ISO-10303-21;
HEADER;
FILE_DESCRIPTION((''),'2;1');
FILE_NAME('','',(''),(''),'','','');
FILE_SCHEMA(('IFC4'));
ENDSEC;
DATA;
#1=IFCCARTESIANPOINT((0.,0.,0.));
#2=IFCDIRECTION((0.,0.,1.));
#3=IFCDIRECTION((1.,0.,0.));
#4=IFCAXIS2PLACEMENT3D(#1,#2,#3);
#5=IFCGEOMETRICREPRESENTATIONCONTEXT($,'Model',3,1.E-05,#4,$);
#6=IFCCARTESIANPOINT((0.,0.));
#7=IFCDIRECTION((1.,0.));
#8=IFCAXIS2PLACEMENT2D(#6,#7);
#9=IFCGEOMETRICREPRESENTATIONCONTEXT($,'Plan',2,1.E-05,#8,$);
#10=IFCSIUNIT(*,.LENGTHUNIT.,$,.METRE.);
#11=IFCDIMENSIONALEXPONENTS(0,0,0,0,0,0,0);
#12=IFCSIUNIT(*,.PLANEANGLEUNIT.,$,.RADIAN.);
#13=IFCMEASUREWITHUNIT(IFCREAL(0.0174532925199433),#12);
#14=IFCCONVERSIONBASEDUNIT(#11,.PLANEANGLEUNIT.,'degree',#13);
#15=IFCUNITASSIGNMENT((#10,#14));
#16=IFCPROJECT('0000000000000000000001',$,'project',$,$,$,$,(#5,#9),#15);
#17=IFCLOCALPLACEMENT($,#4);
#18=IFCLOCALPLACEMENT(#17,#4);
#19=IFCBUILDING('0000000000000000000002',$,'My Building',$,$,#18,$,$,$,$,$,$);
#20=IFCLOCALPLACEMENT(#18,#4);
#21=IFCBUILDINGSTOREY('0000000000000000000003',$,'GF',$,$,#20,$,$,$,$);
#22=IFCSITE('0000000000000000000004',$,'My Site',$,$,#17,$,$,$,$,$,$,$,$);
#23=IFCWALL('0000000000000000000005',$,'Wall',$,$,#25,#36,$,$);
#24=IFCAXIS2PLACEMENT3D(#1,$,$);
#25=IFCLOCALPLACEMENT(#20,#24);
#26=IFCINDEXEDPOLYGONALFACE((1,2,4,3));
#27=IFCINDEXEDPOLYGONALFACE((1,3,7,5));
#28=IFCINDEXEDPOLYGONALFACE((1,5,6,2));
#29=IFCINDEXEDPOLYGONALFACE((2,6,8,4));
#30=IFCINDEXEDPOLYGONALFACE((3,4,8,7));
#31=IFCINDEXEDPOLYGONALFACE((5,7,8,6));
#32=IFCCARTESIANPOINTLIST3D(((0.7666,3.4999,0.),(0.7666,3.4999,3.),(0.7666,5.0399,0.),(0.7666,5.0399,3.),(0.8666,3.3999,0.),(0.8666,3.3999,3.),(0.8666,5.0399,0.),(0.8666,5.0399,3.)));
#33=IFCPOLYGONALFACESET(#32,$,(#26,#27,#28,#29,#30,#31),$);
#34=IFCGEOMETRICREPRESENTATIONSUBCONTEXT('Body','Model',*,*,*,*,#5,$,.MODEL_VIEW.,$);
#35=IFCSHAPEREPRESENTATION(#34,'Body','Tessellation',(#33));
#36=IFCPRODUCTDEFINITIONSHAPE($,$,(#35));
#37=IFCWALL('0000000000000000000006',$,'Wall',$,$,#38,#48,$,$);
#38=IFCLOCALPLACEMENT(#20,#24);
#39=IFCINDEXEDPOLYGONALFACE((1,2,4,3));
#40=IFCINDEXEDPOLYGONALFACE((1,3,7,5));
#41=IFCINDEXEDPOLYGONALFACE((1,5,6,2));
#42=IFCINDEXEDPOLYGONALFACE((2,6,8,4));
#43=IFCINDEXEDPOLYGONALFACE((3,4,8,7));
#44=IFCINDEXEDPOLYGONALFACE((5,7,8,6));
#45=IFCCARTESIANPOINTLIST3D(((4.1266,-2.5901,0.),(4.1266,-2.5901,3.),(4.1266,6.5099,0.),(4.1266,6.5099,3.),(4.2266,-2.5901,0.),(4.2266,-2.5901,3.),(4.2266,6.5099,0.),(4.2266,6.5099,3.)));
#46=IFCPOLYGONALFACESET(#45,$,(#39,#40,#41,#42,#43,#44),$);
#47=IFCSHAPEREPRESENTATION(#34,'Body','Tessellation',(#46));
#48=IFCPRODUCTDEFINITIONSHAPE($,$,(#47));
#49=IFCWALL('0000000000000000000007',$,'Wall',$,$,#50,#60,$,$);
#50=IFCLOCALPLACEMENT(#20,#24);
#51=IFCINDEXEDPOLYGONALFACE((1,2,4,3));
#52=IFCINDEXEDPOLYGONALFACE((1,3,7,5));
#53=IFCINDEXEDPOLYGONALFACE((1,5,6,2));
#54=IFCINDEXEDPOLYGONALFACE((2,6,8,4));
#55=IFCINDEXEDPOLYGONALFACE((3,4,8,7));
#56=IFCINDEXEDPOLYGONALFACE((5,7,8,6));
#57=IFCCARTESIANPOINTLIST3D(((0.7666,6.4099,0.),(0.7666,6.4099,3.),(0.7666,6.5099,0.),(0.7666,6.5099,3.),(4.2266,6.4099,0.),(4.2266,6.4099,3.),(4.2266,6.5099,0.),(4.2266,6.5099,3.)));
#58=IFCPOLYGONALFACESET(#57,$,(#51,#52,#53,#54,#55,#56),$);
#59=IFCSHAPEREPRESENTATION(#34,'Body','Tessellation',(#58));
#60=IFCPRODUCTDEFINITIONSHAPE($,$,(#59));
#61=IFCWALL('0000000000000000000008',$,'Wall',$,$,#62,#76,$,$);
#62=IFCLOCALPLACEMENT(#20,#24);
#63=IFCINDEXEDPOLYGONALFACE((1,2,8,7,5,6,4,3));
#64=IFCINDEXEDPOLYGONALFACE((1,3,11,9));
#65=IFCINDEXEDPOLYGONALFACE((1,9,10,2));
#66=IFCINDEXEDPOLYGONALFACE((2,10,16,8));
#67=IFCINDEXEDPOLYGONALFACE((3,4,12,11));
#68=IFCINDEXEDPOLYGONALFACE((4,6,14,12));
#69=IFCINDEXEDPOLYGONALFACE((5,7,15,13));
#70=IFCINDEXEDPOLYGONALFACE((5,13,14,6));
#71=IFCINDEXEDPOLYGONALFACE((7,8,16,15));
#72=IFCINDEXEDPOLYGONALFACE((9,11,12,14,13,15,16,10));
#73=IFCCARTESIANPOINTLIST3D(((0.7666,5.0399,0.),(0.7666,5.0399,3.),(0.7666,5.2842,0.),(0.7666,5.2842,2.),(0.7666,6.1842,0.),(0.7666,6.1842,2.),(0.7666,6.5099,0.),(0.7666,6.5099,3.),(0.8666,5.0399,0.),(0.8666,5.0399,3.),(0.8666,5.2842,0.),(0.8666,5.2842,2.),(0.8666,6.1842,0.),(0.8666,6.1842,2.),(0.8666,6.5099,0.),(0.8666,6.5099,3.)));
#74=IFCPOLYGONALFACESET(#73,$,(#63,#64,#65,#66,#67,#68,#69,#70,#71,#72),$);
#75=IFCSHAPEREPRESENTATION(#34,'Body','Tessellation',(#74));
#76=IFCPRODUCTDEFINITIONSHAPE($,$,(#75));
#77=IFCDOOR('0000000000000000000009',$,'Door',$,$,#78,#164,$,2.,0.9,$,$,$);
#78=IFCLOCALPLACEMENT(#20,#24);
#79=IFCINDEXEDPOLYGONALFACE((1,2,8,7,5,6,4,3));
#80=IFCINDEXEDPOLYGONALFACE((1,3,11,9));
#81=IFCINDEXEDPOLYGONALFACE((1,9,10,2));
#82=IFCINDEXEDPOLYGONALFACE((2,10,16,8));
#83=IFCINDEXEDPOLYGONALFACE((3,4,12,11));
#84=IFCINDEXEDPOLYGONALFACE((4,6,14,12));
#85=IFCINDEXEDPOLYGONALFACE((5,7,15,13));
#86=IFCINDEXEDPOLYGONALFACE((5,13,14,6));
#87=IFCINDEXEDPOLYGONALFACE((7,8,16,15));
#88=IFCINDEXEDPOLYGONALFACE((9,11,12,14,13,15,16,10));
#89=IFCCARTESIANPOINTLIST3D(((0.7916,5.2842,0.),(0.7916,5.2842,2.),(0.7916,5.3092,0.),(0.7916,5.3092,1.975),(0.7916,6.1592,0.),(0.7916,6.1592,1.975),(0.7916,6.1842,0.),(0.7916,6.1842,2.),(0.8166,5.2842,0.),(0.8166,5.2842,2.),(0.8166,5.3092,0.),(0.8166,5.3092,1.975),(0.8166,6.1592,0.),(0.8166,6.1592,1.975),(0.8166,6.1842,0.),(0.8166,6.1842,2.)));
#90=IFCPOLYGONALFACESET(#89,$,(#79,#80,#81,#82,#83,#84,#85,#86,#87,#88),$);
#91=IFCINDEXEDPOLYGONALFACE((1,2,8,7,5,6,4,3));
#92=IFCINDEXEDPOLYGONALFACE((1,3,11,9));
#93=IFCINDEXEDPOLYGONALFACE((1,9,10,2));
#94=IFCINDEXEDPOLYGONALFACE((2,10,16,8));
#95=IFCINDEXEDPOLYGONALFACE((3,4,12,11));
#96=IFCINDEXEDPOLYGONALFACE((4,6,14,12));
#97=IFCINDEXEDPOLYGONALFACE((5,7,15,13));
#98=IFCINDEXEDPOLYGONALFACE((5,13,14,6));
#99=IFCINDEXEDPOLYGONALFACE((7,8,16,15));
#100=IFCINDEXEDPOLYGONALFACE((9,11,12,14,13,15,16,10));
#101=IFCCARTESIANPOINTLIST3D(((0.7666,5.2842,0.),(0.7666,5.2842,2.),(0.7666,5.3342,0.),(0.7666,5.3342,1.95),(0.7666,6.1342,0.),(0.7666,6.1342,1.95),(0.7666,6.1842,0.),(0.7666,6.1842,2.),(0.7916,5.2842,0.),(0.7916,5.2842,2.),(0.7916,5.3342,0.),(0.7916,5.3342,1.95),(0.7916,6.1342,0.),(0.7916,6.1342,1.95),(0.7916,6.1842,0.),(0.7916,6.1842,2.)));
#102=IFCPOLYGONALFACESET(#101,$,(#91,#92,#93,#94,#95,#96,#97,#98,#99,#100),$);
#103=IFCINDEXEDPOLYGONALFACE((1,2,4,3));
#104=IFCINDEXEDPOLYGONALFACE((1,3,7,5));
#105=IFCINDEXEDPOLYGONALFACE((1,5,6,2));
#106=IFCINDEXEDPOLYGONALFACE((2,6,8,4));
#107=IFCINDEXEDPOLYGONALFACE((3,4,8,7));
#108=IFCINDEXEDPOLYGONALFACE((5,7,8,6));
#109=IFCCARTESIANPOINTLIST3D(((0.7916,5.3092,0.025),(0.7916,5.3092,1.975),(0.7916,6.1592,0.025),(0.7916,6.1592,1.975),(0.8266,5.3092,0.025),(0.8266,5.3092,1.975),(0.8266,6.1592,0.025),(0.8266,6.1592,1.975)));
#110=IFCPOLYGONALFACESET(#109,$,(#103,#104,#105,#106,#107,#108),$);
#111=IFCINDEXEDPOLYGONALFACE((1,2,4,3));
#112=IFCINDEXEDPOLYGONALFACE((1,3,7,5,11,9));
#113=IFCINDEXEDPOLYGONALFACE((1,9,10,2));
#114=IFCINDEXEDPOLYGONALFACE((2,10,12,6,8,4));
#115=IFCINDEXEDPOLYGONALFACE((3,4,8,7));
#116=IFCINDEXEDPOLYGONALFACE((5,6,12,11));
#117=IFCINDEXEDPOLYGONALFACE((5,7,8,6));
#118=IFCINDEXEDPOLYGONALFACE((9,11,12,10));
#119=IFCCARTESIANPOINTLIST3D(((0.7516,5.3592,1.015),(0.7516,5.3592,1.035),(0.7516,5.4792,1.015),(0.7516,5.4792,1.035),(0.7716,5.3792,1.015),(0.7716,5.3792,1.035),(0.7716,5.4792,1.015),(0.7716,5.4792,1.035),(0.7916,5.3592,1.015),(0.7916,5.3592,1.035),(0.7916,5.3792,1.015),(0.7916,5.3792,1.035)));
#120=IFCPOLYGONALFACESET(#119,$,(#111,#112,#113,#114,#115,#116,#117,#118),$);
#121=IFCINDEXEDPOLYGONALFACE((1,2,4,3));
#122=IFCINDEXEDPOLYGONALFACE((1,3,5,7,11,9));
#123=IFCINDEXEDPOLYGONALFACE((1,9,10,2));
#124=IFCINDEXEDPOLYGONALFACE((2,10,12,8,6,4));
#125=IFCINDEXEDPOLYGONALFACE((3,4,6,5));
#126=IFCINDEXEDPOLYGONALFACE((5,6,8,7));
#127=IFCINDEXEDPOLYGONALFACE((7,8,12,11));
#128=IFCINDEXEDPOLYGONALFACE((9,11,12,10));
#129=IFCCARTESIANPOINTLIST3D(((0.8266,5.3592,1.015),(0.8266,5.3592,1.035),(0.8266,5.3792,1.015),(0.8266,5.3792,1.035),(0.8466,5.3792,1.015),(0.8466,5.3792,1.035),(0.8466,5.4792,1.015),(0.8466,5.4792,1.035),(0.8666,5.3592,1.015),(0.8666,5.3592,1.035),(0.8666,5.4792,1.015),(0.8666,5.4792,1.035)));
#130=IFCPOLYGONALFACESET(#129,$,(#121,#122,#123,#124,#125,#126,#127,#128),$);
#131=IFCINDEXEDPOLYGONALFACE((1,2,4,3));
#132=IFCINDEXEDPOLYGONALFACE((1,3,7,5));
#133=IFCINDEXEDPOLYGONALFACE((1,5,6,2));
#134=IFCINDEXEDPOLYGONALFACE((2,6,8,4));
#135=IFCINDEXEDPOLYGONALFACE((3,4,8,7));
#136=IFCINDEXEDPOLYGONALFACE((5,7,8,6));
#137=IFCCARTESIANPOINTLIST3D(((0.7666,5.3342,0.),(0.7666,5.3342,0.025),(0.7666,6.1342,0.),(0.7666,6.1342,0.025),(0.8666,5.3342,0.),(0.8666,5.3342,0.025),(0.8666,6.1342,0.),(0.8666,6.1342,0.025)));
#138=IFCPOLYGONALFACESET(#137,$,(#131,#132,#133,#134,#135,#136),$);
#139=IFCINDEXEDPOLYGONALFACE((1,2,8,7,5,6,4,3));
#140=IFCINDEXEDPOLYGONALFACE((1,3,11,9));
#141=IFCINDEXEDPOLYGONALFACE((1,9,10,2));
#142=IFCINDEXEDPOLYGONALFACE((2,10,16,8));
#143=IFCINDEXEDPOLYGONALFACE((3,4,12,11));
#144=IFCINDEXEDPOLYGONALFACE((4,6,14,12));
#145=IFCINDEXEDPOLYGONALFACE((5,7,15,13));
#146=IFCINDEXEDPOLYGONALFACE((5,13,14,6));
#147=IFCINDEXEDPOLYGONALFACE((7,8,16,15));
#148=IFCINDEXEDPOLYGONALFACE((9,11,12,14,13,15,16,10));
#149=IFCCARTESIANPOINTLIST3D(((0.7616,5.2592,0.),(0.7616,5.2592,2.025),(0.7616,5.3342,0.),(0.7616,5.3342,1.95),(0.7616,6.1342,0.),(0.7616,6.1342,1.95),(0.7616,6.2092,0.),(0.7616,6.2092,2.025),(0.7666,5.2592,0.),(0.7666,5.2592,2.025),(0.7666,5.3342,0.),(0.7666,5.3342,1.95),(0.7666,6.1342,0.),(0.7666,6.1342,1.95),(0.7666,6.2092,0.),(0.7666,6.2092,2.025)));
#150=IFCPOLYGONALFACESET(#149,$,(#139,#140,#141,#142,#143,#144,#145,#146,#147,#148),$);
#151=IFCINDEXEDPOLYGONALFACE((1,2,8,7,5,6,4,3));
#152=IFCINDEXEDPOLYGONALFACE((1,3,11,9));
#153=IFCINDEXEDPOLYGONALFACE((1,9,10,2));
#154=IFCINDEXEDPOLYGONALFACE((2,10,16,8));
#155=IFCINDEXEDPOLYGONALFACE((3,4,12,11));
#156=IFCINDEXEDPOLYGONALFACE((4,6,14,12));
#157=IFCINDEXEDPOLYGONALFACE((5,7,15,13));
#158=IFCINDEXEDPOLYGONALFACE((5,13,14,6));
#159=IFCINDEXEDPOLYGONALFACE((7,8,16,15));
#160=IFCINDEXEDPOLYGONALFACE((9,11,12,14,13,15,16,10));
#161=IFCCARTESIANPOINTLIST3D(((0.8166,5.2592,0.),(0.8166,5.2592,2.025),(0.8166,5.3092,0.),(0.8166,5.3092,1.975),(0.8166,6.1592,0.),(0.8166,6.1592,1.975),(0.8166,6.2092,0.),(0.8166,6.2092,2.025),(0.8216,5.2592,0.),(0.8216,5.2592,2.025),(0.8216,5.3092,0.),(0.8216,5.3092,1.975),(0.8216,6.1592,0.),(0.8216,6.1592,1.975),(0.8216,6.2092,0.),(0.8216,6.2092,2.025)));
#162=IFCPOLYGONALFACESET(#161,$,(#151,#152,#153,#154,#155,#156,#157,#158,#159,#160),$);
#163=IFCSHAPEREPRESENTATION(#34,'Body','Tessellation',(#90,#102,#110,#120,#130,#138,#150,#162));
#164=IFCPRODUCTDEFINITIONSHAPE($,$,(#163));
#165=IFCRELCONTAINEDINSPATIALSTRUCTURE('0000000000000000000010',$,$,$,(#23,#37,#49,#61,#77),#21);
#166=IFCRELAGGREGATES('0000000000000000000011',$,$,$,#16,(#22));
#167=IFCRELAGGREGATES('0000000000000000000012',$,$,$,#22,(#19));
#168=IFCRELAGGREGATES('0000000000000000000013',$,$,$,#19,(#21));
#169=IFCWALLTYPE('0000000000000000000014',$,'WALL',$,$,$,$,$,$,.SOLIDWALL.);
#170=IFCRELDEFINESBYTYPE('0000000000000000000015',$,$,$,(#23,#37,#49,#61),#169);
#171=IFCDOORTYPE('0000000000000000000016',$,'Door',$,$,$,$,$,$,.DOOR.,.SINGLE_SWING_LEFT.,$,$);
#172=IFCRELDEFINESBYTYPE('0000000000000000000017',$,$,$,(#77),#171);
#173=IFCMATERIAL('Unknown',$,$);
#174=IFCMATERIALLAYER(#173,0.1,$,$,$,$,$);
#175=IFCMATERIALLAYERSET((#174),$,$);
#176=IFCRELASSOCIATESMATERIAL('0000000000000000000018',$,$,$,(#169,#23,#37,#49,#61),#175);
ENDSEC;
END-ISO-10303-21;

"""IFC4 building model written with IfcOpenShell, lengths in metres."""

from ifc_helpers import new_model, entity, si_unit, converted_unit, frame, origin_with_axes, origin_2d_with_axis, place, context, subcontext, project, spatial, line, indexed_curve, outline, extrude, shape, source, transform, mapped, material, layer, layer_set, layer_usage, type_object, type_shapes, element, fill, save


model = new_model("IFC4")

# Units and contexts
model_context = context("Model", 3, precision=1e-05, world=origin_with_axes())
plan_context = context("Plan", 2, precision=1e-05, world=origin_2d_with_axis())
body_context_1 = subcontext(model_context, "Body", "Model", "MODEL_VIEW")
body_context_2 = subcontext(plan_context, "Body", "Plan", "PLAN_VIEW")
ifc_project = project(units=[si_unit("LENGTHUNIT", "METRE"), converted_unit("PLANEANGLEUNIT", "degree", entity("IfcReal", 0.0174532925199433), si_unit("PLANEANGLEUNIT", "RADIAN"), dimensions=[0, 0, 0, 0, 0, 0, 0])], contexts=[model_context, plan_context])

# Site, building, storey
site_placement = place(None, origin_with_axes())
site = spatial("IfcSite", under=ifc_project, at=site_placement, Name="My Site")
building_placement = place(site_placement, origin_with_axes())
building = spatial("IfcBuilding", under=site, at=building_placement, Name="My Building")
storey_placement = place(building_placement, origin_with_axes())
storey = spatial("IfcBuildingStorey", under=building, at=storey_placement, Name="GF")

# Shared definitions
ifc_material = material(Name="Unknown")

# Shared definitions
ifc_layer_1 = layer(ifc_material, 0.1)
ifc_layer_set_1 = layer_set([ifc_layer_1])
wall_type_1 = type_object("IfcWallType", Name="WALL", PredefinedType="SOLIDWALL", material=ifc_layer_set_1)

# Shared definitions
shared_shape_1 = source(origin_with_axes(), body_context_1, "Body", "SweptSolid", [
    extrude(outline(indexed_curve([(0.0, 0.0), (0.9, 0.0), (0.9, 2.0), (0.0, 2.0)], segments=[line(1, 2, 3, 4, 1)])), frame((0.0, -0.6, 0.0), z_axis=(0.0, -1.0, 0.0), x_axis=(1.0, 0.0, 0.0)), (0.0, 0.0, -1.0), 1.2),
])
door_type = type_object("IfcDoorType", Name="Door", OperationType="SINGLE_SWING_LEFT", PredefinedType="DOOR")
shared_shape_2 = source(origin_with_axes(), body_context_1, "Body", "SweptSolid", [
    extrude(outline(indexed_curve([(0.0, 0.0), (0.0, 2.0), (0.9, 2.0), (0.9, 0.0), (0.875, 0.0), (0.875, 1.975), (0.025, 1.975), (0.025, 0.0)], segments=[line(1, 2, 3, 4, 5, 6, 7, 8, 1)])), frame((0.0, 0.025, 0.0), z_axis=(0.0, -1.0, 0.0), x_axis=(1.0, 0.0, 0.0)), (0.0, 0.0, -1.0), 0.025),
    extrude(outline(indexed_curve([(0.0, 0.0), (0.0, 2.0), (0.9, 2.0), (0.9, 0.0), (0.85, 0.0), (0.85, 1.95), (0.05, 1.95), (0.05, 0.0)], segments=[line(1, 2, 3, 4, 5, 6, 7, 8, 1)])), frame((0.0, 0.0, 0.0), z_axis=(0.0, -1.0, 0.0), x_axis=(1.0, 0.0, 0.0)), (0.0, 0.0, -1.0), 0.025),
    extrude(outline(indexed_curve([(0.0, 0.0), (0.85, 0.0), (0.85, 0.035), (0.0, 0.035)], segments=[line(1, 2, 3, 4, 1)])), frame((0.025, 0.025, 0.025), z_axis=(0.0, 0.0, 1.0), x_axis=(1.0, 0.0, 0.0)), (0.0, 0.0, 1.0), 1.95),
    extrude(outline(indexed_curve([(0.0, 0.0), (0.0, -0.04), (-0.12, -0.04), (-0.12, -0.02), (-0.02, -0.02), (-0.02, 0.0)], segments=[line(1, 2, 3, 4, 5, 6, 1)])), frame((0.825, 0.025, 1.015), z_axis=(0.0, 0.0, 1.0), x_axis=(1.0, 0.0, 0.0)), (0.0, 0.0, 1.0), 0.02),
    extrude(outline(indexed_curve([(0.0, 0.0), (0.0, 0.04), (-0.12, 0.04), (-0.12, 0.02), (-0.02, 0.02), (-0.02, 0.0)], segments=[line(1, 2, 3, 4, 5, 6, 1)])), frame((0.825, 0.06, 1.015), z_axis=(0.0, 0.0, 1.0), x_axis=(1.0, 0.0, 0.0)), (0.0, 0.0, 1.0), 0.02),
    extrude(outline(indexed_curve([(0.0, 0.0), (0.8, 0.0), (0.8, 0.1), (0.0, 0.1)], segments=[line(1, 2, 3, 4, 1)])), frame((0.05, 0.0, 0.0), z_axis=(0.0, 0.0, 1.0), x_axis=(1.0, 0.0, 0.0)), (0.0, 0.0, 1.0), 0.025),
    extrude(outline(indexed_curve([(0.0, 0.0), (0.0, 2.025), (0.95, 2.025), (0.95, 0.0), (0.875, 0.0), (0.875, 1.95), (0.075, 1.95), (0.075, 0.0)], segments=[line(1, 2, 3, 4, 5, 6, 7, 8, 1)])), frame((-0.025, -0.005, 0.0), z_axis=(0.0, -1.0, 0.0), x_axis=(1.0, 0.0, 0.0)), (0.0, 0.0, -1.0), 0.005),
    extrude(outline(indexed_curve([(0.0, 0.0), (0.0, 2.025), (0.95, 2.025), (0.95, 0.0), (0.9, 0.0), (0.9, 1.975), (0.05, 1.975), (0.05, 0.0)], segments=[line(1, 2, 3, 4, 5, 6, 7, 8, 1)])), frame((-0.025, 0.05, 0.0), z_axis=(0.0, -1.0, 0.0), x_axis=(1.0, 0.0, 0.0)), (0.0, 0.0, -1.0), 0.005),
])
shared_shape_3 = source(origin_with_axes(), body_context_2, "Body", "Curve2D", [
    entity("IfcIndexedPolyCurve", entity("IfcCartesianPointList2D", [[0.0, 0.0], [0.0, 0.05], [0.025, 0.05], [0.025, 0.025], [0.05, 0.025], [0.05, 0.0]]), [entity("IfcLineIndex", [1, 2, 3, 4, 5, 6, 1])]),
    entity("IfcIndexedPolyCurve", entity("IfcCartesianPointList2D", [[0.9, 0.0], [0.9, 0.05], [0.875, 0.05], [0.875, 0.025], [0.85, 0.025], [0.85, 0.0]]), [entity("IfcLineIndex", [1, 2, 3, 4, 5, 6, 1])]),
    entity("IfcTrimmedCurve", entity("IfcEllipse", entity("IfcAxis2Placement2D", entity("IfcCartesianPoint", [0.06, 0.05]), entity("IfcDirection", [1.0, 0.0])), 0.815, 0.85), [entity("IfcCartesianPoint", [0.875, 0.05])], [entity("IfcCartesianPoint", [0.06, 0.9])], True, "CARTESIAN"),
    entity("IfcIndexedPolyCurve", entity("IfcCartesianPointList2D", [[0.025, 0.05], [0.06, 0.05], [0.06, 0.9], [0.025, 0.9]]), [entity("IfcLineIndex", [1, 2, 3, 4, 1])]),
])
type_shapes(door_type, [shared_shape_2, shared_shape_3])

# Walls
ifc_layer_usage_1 = layer_usage(ifc_layer_set_1, "AXIS2", "POSITIVE", 0.0)
wall_1_placement = place(storey_placement, frame((0.8666, 3.3999, 0.0), z_axis=(0.0, 0.0, 1.0), x_axis=(0.0, 1.0, 0.0)))
element("IfcWall", 1, at=wall_1_placement, inside=storey, type_object=wall_type_1, material=ifc_layer_usage_1, Name="Wall", context=body_context_1, shape_type="SweptSolid", body=[
    extrude(outline(indexed_curve([(0.0, 0.0), (0.1, 0.1), (1.64, 0.1), (1.64, 0.0)], segments=[line(1, 2, 3, 4, 1)])), origin_with_axes(), (0.0, 0.0, 1.0), 3.0),
])
ifc_layer_usage_2 = layer_usage(ifc_layer_set_1, "AXIS2", "POSITIVE", 0.0)
wall_2_placement = place(storey_placement, frame((4.2266, -2.5901, 0.0), z_axis=(0.0, 0.0, 1.0), x_axis=(0.0, 1.0, 0.0)))
element("IfcWall", 2, at=wall_2_placement, inside=storey, type_object=wall_type_1, material=ifc_layer_usage_2, Name="Wall", context=body_context_1, shape_type="SweptSolid", body=[
    extrude(outline(indexed_curve([(0.0, 0.0), (0.0, 0.1), (9.1, 0.1), (9.1, 0.0)], segments=[line(1, 2, 3, 4, 1)])), origin_with_axes(), (0.0, 0.0, 1.0), 3.0),
])
ifc_layer_usage_3 = layer_usage(ifc_layer_set_1, "AXIS2", "POSITIVE", 0.0)
wall_3_placement = place(storey_placement, frame((4.2266, 6.5099, 0.0), z_axis=(0.0, 0.0, 1.0), x_axis=(-1.0, 0.0, 0.0)))
element("IfcWall", 3, at=wall_3_placement, inside=storey, type_object=wall_type_1, material=ifc_layer_usage_3, Name="Wall", context=body_context_1, shape_type="SweptSolid", body=[
    extrude(outline(indexed_curve([(0.0, 0.0), (0.0, 0.1), (3.46, 0.1), (3.46, 0.0)], segments=[line(1, 2, 3, 4, 1)])), origin_with_axes(), (0.0, 0.0, 1.0), 3.0),
])

# Wall, opening, door
ifc_layer_usage_4 = layer_usage(ifc_layer_set_1, "AXIS2", "POSITIVE", 0.0)
wall_4_placement = place(storey_placement, frame((0.7666, 6.5099, 0.0), z_axis=(0.0, 0.0, 1.0), x_axis=(0.0, -1.0, 0.0)))
wall_4 = element("IfcWall", 4, at=wall_4_placement, inside=storey, type_object=wall_type_1, material=ifc_layer_usage_4, Name="Wall", context=body_context_1, shape_type="SweptSolid", body=[
    extrude(outline(indexed_curve([(0.0, 0.0), (0.0, 0.1), (1.47, 0.1), (1.47, 0.0)], segments=[line(1, 2, 3, 4, 1)])), origin_with_axes(), (0.0, 0.0, 1.0), 3.0),
])
opening_1_placement = place(wall_4_placement, frame((0.3257, 0.0, 0.0), z_axis=(0.0, 0.0, 1.0), x_axis=(1.0, 0.0, 0.0)))
opening_1 = element("IfcOpeningElement", 5, at=opening_1_placement, cuts=wall_4, PredefinedType="OPENING", context=body_context_1, shape_type="MappedRepresentation", body=[
    mapped(shared_shape_1, transform((0.0, 0.0, 0.0), x_axis=(1.0, 0.0, 0.0), y_axis=(0.0, 1.0, 0.0), z_axis=(0.0, 0.0, 1.0), scale=1.0)),
])
door_1_placement = place(opening_1_placement, frame((0.0, 0.0, 0.0), z_axis=(0.0, 0.0, 1.0), x_axis=(1.0, 0.0, 0.0)))
door_1 = element("IfcDoor", 6, at=door_1_placement, inside=storey, type_object=door_type, Name="Door", OverallHeight=2.0, OverallWidth=0.9, shapes=[
    shape(body_context_1, "Body", "MappedRepresentation", [mapped(shared_shape_2, transform((0.0, 0.0, 0.0), x_axis=(1.0, 0.0, 0.0), y_axis=(0.0, 1.0, 0.0), z_axis=(0.0, 0.0, 1.0), scale=1.0))]),
    shape(body_context_2, "Body", "MappedRepresentation", [mapped(shared_shape_3, transform((0.0, 0.0, 0.0), x_axis=(1.0, 0.0, 0.0), y_axis=(0.0, 1.0, 0.0), z_axis=(0.0, 0.0, 1.0), scale=1.0))]),
])
fill(opening_1, door_1)

save(model, "model.ifc")
